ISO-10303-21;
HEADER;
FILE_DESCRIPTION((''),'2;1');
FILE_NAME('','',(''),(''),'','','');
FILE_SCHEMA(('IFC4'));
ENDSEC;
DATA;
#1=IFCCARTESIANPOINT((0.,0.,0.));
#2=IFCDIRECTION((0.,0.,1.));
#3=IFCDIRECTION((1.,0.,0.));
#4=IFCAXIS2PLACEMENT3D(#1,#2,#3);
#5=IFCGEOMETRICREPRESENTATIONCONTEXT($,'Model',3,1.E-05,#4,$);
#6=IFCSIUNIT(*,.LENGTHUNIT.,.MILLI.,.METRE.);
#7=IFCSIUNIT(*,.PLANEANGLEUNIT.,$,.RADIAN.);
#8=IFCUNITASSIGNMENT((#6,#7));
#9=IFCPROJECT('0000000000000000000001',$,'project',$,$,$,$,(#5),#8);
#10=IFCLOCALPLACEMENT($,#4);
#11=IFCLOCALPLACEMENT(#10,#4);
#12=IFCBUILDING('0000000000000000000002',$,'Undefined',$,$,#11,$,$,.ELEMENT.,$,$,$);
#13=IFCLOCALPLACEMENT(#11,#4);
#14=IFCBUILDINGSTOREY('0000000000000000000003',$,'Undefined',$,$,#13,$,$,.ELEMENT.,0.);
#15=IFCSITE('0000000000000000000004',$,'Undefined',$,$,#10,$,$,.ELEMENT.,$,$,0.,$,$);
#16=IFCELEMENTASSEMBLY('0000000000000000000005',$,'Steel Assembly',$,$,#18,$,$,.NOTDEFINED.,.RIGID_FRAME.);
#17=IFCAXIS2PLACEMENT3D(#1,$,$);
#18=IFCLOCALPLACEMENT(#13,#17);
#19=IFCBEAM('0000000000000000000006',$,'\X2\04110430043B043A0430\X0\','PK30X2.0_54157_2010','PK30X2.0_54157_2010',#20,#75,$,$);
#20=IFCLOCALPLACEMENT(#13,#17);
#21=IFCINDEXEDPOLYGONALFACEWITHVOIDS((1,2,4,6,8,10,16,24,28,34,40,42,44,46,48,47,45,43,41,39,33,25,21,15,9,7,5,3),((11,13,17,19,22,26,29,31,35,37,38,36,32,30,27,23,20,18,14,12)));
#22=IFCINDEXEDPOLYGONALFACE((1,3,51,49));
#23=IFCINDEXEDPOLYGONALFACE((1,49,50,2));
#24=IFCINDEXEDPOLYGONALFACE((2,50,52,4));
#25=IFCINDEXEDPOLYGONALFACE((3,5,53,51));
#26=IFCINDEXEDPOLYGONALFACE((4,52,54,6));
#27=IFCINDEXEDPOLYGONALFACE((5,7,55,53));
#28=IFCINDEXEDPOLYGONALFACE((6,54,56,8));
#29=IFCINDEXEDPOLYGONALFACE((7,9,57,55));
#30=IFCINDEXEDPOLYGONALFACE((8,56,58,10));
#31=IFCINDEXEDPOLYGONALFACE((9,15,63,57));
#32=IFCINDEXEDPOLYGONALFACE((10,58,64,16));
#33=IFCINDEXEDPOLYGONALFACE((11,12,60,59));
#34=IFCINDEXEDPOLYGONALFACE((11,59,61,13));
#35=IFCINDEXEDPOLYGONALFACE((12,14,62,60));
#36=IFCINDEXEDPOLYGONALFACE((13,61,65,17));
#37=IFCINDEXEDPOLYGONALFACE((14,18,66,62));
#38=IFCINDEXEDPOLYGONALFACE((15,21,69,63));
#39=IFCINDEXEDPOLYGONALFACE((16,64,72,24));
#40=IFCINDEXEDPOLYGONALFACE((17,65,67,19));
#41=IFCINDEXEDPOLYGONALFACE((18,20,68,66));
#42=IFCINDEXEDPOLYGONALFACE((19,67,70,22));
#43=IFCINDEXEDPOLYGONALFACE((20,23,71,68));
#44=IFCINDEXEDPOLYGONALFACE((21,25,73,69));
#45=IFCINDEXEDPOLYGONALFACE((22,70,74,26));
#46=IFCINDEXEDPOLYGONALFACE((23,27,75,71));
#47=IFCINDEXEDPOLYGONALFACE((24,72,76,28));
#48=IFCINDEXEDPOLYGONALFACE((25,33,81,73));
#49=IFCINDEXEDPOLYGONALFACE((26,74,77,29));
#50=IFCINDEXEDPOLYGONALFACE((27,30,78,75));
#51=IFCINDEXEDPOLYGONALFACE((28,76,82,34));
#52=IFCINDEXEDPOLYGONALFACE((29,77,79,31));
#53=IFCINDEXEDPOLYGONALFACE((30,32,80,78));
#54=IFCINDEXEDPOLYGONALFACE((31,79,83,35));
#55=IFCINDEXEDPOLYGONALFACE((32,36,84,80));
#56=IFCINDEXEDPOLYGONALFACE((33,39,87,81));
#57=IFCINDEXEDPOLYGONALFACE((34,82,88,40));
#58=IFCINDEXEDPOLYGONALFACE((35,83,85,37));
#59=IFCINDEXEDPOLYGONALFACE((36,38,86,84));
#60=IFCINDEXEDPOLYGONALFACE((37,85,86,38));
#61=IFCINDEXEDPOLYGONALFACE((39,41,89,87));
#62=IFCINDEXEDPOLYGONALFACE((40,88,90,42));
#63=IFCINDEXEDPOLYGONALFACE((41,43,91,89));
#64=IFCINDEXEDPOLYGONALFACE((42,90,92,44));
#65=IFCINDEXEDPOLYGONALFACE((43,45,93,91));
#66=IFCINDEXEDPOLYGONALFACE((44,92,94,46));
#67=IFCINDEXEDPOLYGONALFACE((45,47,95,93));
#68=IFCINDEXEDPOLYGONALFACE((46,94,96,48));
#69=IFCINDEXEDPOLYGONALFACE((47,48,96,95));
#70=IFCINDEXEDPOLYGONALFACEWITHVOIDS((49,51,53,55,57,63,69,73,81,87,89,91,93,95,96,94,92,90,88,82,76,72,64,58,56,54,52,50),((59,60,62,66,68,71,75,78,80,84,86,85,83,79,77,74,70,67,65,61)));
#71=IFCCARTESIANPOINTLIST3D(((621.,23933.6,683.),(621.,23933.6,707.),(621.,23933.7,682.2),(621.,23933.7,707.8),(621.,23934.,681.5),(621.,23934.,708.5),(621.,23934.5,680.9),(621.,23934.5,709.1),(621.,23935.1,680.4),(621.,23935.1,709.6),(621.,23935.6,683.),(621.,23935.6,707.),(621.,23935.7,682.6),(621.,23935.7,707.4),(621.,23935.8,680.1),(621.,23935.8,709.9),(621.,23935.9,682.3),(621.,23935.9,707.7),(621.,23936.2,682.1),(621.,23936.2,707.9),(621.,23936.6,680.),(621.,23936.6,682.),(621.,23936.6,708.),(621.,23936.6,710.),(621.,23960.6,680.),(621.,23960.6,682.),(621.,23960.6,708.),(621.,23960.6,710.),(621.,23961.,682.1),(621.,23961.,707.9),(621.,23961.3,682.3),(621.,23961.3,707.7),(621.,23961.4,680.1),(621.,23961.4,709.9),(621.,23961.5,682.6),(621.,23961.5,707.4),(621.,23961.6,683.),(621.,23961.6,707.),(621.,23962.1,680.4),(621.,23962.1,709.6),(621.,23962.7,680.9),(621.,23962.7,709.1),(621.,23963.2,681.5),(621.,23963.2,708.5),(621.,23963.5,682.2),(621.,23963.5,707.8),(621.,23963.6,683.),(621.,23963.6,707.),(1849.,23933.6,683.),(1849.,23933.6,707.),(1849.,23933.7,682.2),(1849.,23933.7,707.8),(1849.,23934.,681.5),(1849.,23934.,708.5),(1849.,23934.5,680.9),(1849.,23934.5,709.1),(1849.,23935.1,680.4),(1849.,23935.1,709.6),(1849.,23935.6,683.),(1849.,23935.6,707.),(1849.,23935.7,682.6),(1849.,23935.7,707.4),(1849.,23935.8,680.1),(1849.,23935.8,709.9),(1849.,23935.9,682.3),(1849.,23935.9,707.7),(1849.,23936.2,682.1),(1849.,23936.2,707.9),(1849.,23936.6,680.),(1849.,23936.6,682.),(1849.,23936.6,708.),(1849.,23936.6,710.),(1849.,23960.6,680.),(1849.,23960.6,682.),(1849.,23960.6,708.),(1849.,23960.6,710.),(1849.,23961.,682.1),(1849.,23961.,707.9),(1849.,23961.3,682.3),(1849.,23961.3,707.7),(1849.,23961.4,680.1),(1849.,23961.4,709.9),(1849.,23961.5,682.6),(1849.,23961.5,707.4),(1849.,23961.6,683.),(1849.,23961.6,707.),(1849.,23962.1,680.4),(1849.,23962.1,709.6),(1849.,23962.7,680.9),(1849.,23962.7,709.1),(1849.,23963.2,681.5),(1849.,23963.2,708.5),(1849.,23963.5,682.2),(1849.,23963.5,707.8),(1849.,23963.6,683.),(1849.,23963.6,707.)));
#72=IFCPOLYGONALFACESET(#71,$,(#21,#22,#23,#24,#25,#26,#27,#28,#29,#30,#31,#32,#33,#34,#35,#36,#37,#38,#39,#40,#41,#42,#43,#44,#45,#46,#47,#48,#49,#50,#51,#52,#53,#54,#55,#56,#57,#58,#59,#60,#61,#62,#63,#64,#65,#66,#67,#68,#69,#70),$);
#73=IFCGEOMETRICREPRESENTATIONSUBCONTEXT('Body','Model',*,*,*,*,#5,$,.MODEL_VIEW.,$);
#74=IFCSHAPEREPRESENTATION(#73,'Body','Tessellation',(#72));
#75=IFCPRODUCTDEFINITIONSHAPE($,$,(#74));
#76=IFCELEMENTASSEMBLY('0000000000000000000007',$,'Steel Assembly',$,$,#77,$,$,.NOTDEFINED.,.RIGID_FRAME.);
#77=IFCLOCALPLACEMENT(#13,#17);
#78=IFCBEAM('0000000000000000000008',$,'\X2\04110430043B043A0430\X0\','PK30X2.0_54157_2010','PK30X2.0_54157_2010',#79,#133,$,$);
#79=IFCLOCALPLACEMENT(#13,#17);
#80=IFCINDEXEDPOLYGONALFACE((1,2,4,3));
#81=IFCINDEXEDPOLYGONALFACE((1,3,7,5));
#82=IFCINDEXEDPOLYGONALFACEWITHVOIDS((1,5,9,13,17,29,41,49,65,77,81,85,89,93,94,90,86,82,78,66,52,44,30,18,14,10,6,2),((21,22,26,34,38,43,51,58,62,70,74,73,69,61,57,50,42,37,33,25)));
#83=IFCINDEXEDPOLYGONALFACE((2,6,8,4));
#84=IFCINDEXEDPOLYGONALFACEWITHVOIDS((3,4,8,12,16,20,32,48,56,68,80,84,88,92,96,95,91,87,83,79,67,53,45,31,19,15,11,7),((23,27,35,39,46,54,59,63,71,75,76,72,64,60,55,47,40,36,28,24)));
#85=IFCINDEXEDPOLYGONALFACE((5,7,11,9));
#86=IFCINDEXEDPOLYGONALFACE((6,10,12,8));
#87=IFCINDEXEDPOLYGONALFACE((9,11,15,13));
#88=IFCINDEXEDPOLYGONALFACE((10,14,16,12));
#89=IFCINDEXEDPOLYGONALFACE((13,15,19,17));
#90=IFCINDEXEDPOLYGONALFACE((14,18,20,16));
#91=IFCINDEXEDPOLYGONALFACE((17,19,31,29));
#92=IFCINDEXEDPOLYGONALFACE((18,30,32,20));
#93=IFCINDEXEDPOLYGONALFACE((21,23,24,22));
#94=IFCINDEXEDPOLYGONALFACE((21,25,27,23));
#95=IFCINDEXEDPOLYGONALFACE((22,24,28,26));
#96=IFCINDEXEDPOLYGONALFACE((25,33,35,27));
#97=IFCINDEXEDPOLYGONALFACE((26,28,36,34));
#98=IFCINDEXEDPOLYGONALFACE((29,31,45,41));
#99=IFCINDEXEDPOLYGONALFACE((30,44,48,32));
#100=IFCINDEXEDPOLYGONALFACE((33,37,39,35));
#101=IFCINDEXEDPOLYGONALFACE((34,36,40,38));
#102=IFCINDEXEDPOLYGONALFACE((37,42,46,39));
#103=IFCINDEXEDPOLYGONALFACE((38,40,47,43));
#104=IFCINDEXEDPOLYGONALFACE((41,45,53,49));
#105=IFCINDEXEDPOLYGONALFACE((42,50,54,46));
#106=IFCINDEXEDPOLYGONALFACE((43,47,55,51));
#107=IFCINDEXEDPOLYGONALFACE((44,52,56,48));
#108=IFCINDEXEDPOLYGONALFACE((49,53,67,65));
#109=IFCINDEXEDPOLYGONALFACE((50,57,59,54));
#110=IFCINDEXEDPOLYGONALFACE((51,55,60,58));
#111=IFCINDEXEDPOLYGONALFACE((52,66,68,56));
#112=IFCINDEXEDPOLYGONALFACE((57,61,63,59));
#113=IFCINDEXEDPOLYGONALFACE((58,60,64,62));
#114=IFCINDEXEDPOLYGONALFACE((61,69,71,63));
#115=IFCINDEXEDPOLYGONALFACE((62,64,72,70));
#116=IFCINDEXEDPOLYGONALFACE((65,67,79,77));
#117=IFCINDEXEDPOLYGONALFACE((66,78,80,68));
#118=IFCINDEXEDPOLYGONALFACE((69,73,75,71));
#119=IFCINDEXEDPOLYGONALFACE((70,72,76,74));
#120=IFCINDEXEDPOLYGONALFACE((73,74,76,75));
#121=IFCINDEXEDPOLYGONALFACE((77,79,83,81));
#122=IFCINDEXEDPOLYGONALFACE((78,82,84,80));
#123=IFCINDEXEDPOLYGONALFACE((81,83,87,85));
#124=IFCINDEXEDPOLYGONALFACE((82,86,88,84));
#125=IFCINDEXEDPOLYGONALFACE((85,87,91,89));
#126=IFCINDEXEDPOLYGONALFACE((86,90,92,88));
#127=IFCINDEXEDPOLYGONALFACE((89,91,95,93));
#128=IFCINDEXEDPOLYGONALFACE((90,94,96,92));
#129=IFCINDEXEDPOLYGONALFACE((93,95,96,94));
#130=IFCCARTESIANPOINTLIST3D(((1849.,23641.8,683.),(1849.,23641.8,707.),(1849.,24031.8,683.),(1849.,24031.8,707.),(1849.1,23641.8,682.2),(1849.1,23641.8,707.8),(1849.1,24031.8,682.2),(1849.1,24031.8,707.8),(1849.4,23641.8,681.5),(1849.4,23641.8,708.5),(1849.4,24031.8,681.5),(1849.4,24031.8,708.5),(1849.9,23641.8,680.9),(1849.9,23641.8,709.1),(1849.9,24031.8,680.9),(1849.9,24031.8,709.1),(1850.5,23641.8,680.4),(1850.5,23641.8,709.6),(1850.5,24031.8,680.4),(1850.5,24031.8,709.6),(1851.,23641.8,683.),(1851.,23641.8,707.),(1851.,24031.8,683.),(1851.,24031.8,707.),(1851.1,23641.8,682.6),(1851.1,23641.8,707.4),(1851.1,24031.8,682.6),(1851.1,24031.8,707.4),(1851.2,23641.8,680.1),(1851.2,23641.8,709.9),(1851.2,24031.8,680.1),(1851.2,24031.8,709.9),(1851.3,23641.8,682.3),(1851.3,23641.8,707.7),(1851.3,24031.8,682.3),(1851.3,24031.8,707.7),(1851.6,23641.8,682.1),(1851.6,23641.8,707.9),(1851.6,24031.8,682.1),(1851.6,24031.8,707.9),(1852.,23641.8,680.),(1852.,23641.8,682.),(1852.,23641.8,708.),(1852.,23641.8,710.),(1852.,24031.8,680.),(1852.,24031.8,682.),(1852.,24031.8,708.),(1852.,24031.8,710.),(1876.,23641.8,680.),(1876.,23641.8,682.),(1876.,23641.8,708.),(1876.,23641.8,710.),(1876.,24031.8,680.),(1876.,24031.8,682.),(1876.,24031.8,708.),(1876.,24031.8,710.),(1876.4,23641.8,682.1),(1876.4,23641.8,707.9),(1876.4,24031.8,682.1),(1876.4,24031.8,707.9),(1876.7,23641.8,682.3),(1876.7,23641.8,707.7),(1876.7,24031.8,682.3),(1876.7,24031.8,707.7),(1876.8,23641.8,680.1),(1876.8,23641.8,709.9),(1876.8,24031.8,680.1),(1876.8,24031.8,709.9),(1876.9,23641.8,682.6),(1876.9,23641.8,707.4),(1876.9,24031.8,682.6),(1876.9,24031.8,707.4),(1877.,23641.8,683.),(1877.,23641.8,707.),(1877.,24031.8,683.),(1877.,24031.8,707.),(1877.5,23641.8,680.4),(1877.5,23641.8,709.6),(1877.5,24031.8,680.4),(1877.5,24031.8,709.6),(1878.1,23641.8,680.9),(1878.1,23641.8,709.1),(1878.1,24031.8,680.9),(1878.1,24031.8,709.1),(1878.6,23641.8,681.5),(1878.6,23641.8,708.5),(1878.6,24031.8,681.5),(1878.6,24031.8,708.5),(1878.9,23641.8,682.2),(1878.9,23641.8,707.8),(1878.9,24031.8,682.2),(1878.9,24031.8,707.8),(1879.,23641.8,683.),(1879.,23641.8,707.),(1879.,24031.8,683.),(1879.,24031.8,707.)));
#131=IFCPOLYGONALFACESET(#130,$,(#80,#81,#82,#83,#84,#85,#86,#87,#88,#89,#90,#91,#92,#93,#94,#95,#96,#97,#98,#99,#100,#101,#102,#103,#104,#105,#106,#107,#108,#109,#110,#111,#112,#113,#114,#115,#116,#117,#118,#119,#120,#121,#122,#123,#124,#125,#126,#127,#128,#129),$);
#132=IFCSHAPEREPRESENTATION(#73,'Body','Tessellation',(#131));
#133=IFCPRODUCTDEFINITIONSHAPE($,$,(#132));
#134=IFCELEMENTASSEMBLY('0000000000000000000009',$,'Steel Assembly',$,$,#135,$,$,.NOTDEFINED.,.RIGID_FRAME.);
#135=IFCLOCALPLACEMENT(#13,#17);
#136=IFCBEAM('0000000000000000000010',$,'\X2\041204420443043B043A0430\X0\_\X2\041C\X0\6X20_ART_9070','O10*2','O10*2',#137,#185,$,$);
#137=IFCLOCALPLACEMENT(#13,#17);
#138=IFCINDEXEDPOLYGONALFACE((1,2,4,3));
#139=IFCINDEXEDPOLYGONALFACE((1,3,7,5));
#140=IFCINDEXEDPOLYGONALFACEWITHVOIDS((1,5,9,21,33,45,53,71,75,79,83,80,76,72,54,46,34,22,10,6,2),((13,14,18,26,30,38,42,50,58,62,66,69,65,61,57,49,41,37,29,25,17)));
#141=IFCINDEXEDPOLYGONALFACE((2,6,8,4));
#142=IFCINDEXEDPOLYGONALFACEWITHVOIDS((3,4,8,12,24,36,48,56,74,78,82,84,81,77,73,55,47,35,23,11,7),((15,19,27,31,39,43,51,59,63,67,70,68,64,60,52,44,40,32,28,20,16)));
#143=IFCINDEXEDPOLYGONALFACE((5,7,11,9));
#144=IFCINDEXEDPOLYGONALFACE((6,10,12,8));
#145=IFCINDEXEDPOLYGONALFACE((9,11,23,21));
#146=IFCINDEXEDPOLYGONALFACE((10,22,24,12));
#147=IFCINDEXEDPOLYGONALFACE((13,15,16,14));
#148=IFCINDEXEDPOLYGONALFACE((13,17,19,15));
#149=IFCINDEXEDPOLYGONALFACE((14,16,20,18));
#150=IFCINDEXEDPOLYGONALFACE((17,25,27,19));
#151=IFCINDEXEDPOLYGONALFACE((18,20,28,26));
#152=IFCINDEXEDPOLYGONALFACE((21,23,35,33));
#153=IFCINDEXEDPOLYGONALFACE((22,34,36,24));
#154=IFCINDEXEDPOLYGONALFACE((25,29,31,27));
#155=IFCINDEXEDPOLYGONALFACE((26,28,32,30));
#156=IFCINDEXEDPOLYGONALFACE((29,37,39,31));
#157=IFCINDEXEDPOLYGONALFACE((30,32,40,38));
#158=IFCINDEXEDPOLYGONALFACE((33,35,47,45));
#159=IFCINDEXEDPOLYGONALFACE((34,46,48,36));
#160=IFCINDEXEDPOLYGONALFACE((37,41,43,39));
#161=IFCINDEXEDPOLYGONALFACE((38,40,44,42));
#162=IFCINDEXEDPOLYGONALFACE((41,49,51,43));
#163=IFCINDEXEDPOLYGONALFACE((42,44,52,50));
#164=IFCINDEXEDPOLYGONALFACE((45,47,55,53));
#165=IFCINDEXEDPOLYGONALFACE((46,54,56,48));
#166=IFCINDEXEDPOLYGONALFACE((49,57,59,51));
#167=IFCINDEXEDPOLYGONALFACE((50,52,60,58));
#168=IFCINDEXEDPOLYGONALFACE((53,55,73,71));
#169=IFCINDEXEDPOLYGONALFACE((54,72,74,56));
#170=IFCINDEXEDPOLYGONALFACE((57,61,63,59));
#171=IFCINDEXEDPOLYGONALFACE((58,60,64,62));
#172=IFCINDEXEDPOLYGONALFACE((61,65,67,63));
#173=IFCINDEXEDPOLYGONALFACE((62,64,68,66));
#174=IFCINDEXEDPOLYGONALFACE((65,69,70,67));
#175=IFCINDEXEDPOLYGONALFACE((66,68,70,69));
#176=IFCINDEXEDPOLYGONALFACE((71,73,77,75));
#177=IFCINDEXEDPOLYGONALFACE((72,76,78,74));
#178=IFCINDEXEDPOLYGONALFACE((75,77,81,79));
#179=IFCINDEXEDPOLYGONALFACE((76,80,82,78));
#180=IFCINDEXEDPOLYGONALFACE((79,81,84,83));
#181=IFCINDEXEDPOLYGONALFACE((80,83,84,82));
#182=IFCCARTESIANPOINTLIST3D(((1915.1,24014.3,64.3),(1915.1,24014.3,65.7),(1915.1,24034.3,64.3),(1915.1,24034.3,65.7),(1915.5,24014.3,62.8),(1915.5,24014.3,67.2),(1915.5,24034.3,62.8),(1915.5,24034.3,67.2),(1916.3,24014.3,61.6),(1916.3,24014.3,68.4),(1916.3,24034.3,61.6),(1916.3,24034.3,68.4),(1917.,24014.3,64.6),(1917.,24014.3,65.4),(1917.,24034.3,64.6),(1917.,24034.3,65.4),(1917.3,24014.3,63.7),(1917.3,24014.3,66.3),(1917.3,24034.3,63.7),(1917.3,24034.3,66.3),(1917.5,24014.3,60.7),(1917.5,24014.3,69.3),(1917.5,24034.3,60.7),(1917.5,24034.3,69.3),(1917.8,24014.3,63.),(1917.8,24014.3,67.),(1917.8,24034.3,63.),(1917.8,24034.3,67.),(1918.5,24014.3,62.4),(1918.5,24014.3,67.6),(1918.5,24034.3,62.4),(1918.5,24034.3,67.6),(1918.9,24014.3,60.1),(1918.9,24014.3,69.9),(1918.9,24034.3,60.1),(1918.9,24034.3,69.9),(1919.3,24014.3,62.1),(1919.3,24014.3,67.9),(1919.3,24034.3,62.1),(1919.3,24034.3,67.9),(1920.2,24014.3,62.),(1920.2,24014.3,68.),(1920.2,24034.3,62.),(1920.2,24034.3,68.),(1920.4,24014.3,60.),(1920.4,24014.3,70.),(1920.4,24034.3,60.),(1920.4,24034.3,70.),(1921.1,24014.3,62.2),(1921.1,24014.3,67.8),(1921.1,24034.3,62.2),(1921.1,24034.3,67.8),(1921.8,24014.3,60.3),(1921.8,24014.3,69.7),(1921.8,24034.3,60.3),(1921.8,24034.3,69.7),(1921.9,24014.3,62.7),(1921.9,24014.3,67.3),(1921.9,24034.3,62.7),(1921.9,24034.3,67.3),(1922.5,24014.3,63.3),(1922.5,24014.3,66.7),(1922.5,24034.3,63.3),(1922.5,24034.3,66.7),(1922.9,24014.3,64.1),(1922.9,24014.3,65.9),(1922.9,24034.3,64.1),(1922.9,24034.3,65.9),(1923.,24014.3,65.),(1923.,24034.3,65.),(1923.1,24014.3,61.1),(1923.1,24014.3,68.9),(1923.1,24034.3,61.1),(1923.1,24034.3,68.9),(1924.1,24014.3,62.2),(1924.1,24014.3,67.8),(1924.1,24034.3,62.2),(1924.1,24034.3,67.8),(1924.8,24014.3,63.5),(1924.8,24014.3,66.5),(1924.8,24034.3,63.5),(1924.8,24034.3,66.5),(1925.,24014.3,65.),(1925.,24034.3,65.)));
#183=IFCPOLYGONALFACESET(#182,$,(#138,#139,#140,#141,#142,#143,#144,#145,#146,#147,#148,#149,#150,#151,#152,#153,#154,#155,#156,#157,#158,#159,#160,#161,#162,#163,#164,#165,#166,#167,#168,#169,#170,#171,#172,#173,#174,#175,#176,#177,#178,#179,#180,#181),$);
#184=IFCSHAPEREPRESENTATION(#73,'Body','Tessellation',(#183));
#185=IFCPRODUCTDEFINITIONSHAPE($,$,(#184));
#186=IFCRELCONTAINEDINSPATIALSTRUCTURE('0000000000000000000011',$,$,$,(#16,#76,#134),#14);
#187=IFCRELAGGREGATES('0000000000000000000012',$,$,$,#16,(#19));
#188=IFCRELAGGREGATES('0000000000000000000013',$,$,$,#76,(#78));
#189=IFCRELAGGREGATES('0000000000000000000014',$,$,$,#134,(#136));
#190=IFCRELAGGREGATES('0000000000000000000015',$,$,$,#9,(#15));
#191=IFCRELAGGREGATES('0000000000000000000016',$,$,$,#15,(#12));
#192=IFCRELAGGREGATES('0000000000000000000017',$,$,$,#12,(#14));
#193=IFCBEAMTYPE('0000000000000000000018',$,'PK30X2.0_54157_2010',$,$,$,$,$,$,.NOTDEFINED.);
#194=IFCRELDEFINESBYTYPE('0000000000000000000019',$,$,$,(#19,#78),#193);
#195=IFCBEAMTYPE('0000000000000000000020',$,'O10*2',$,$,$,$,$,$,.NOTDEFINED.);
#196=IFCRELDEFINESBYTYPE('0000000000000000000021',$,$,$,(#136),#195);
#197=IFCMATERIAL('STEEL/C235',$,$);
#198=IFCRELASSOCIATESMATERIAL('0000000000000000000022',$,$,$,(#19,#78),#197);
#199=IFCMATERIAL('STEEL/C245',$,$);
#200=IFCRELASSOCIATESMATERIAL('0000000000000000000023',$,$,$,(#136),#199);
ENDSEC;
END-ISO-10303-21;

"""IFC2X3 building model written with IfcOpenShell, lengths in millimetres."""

from ifc_helpers import new_model, si_unit, frame, origin_with_axes, origin_2d_with_axis, place, context, subcontext, project, spatial, hollow_rectangle, hollow_circle, extrude, material, type_object, element, aggregate, save


model = new_model("IFC2X3")

# Units and contexts
model_context = context("Model", 3, precision=1e-05, world=origin_with_axes())
body_context = subcontext(model_context, "Body", "Model", "MODEL_VIEW")
ifc_project = project(units=[si_unit("LENGTHUNIT", "METRE", prefix="MILLI"), si_unit("PLANEANGLEUNIT", "RADIAN")], contexts=[model_context])

# Site, building, storey
site_placement = place(None, origin_with_axes())
site = spatial("IfcSite", under=ifc_project, at=site_placement, Name="Undefined", CompositionType="ELEMENT", RefElevation=0.0)
building_placement = place(site_placement, origin_with_axes())
building = spatial("IfcBuilding", under=site, at=building_placement, Name="Undefined", CompositionType="ELEMENT")
storey_placement = place(building_placement, origin_with_axes())
storey = spatial("IfcBuildingStorey", under=building, at=storey_placement, Name="Undefined", CompositionType="ELEMENT", Elevation=0.0)

# Element assemblies, beams
ifc_material_1 = material(Name="STEEL/C235")
ifc_material_2 = material(Name="STEEL/C245")
assembly_1_placement = place(storey_placement, origin_with_axes())
assembly_1 = element("IfcElementAssembly", 1, at=assembly_1_placement, inside=storey, Name="Steel Assembly", AssemblyPlace="NOTDEFINED", PredefinedType="RIGID_FRAME")
beam_type_1 = type_object("IfcBeamType", Name="PK30X2.0_54157_2010", PredefinedType="NOTDEFINED")
beam_1_placement = place(assembly_1_placement, frame((1849.0, 23948.6, 695.0), z_axis=(0.0, 1.0, 0.0), x_axis=(-1.0, 0.0, 0.0)))
beam_1 = element("IfcBeam", 2, at=beam_1_placement, type_object=beam_type_1, material=ifc_material_1, Name="Балка", Description="PK30X2.0_54157_2010", ObjectType="PK30X2.0_54157_2010", context=body_context, shape_type="SweptSolid", body=[
    extrude(hollow_rectangle(XDim=30.0, YDim=30.0, WallThickness=2.0, InnerFilletRadius=1.0, OuterFilletRadius=3.0, at=origin_2d_with_axis()), frame((1228.0, 0.0, 0.0), z_axis=(-1.0, 0.0, 0.0), x_axis=(0.0, -1.0, 0.0)), (0.0, 0.0, 1.0), 1228.0),
])
aggregate(assembly_1, [beam_1])
assembly_2_placement = place(storey_placement, origin_with_axes())
assembly_2 = element("IfcElementAssembly", 3, at=assembly_2_placement, inside=storey, Name="Steel Assembly", AssemblyPlace="NOTDEFINED", PredefinedType="RIGID_FRAME")
beam_2_placement = place(assembly_2_placement, frame((1864.0, 23641.8, 695.0), z_axis=(1.0, 0.0, 0.0), x_axis=(0.0, 1.0, 0.0)))
beam_2 = element("IfcBeam", 4, at=beam_2_placement, type_object=beam_type_1, material=ifc_material_1, Name="Балка", Description="PK30X2.0_54157_2010", ObjectType="PK30X2.0_54157_2010", context=body_context, shape_type="SweptSolid", body=[
    extrude(hollow_rectangle(XDim=30.0, YDim=30.0, WallThickness=2.0, InnerFilletRadius=1.0, OuterFilletRadius=3.0, at=origin_2d_with_axis()), frame((390.0, 0.0, 0.0), z_axis=(-1.0, 0.0, 0.0), x_axis=(0.0, -1.0, 0.0)), (0.0, 0.0, 1.0), 390.0),
])
aggregate(assembly_2, [beam_2])
assembly_3_placement = place(storey_placement, origin_with_axes())
assembly_3 = element("IfcElementAssembly", 5, at=assembly_3_placement, inside=storey, Name="Steel Assembly", AssemblyPlace="NOTDEFINED", PredefinedType="RIGID_FRAME")
beam_type_2 = type_object("IfcBeamType", Name="O10*2", PredefinedType="NOTDEFINED")
beam_3_placement = place(assembly_3_placement, frame((1920.0, 24014.3, 65.0), z_axis=(0.0, 0.0, 1.0), x_axis=(0.0, 1.0, 0.0)))
beam_3 = element("IfcBeam", 6, at=beam_3_placement, type_object=beam_type_2, material=ifc_material_2, Name="Втулка_М6X20_ART_9070", Description="O10*2", ObjectType="O10*2", context=body_context, shape_type="SweptSolid", body=[
    extrude(hollow_circle(Radius=5.0, WallThickness=2.0, at=origin_2d_with_axis()), frame((20.0, 0.0, 0.0), z_axis=(-1.0, 0.0, 0.0), x_axis=(0.0, -1.0, 0.0)), (0.0, 0.0, 1.0), 20.0),
])
aggregate(assembly_3, [beam_3])

save(model, "model.ifc")
